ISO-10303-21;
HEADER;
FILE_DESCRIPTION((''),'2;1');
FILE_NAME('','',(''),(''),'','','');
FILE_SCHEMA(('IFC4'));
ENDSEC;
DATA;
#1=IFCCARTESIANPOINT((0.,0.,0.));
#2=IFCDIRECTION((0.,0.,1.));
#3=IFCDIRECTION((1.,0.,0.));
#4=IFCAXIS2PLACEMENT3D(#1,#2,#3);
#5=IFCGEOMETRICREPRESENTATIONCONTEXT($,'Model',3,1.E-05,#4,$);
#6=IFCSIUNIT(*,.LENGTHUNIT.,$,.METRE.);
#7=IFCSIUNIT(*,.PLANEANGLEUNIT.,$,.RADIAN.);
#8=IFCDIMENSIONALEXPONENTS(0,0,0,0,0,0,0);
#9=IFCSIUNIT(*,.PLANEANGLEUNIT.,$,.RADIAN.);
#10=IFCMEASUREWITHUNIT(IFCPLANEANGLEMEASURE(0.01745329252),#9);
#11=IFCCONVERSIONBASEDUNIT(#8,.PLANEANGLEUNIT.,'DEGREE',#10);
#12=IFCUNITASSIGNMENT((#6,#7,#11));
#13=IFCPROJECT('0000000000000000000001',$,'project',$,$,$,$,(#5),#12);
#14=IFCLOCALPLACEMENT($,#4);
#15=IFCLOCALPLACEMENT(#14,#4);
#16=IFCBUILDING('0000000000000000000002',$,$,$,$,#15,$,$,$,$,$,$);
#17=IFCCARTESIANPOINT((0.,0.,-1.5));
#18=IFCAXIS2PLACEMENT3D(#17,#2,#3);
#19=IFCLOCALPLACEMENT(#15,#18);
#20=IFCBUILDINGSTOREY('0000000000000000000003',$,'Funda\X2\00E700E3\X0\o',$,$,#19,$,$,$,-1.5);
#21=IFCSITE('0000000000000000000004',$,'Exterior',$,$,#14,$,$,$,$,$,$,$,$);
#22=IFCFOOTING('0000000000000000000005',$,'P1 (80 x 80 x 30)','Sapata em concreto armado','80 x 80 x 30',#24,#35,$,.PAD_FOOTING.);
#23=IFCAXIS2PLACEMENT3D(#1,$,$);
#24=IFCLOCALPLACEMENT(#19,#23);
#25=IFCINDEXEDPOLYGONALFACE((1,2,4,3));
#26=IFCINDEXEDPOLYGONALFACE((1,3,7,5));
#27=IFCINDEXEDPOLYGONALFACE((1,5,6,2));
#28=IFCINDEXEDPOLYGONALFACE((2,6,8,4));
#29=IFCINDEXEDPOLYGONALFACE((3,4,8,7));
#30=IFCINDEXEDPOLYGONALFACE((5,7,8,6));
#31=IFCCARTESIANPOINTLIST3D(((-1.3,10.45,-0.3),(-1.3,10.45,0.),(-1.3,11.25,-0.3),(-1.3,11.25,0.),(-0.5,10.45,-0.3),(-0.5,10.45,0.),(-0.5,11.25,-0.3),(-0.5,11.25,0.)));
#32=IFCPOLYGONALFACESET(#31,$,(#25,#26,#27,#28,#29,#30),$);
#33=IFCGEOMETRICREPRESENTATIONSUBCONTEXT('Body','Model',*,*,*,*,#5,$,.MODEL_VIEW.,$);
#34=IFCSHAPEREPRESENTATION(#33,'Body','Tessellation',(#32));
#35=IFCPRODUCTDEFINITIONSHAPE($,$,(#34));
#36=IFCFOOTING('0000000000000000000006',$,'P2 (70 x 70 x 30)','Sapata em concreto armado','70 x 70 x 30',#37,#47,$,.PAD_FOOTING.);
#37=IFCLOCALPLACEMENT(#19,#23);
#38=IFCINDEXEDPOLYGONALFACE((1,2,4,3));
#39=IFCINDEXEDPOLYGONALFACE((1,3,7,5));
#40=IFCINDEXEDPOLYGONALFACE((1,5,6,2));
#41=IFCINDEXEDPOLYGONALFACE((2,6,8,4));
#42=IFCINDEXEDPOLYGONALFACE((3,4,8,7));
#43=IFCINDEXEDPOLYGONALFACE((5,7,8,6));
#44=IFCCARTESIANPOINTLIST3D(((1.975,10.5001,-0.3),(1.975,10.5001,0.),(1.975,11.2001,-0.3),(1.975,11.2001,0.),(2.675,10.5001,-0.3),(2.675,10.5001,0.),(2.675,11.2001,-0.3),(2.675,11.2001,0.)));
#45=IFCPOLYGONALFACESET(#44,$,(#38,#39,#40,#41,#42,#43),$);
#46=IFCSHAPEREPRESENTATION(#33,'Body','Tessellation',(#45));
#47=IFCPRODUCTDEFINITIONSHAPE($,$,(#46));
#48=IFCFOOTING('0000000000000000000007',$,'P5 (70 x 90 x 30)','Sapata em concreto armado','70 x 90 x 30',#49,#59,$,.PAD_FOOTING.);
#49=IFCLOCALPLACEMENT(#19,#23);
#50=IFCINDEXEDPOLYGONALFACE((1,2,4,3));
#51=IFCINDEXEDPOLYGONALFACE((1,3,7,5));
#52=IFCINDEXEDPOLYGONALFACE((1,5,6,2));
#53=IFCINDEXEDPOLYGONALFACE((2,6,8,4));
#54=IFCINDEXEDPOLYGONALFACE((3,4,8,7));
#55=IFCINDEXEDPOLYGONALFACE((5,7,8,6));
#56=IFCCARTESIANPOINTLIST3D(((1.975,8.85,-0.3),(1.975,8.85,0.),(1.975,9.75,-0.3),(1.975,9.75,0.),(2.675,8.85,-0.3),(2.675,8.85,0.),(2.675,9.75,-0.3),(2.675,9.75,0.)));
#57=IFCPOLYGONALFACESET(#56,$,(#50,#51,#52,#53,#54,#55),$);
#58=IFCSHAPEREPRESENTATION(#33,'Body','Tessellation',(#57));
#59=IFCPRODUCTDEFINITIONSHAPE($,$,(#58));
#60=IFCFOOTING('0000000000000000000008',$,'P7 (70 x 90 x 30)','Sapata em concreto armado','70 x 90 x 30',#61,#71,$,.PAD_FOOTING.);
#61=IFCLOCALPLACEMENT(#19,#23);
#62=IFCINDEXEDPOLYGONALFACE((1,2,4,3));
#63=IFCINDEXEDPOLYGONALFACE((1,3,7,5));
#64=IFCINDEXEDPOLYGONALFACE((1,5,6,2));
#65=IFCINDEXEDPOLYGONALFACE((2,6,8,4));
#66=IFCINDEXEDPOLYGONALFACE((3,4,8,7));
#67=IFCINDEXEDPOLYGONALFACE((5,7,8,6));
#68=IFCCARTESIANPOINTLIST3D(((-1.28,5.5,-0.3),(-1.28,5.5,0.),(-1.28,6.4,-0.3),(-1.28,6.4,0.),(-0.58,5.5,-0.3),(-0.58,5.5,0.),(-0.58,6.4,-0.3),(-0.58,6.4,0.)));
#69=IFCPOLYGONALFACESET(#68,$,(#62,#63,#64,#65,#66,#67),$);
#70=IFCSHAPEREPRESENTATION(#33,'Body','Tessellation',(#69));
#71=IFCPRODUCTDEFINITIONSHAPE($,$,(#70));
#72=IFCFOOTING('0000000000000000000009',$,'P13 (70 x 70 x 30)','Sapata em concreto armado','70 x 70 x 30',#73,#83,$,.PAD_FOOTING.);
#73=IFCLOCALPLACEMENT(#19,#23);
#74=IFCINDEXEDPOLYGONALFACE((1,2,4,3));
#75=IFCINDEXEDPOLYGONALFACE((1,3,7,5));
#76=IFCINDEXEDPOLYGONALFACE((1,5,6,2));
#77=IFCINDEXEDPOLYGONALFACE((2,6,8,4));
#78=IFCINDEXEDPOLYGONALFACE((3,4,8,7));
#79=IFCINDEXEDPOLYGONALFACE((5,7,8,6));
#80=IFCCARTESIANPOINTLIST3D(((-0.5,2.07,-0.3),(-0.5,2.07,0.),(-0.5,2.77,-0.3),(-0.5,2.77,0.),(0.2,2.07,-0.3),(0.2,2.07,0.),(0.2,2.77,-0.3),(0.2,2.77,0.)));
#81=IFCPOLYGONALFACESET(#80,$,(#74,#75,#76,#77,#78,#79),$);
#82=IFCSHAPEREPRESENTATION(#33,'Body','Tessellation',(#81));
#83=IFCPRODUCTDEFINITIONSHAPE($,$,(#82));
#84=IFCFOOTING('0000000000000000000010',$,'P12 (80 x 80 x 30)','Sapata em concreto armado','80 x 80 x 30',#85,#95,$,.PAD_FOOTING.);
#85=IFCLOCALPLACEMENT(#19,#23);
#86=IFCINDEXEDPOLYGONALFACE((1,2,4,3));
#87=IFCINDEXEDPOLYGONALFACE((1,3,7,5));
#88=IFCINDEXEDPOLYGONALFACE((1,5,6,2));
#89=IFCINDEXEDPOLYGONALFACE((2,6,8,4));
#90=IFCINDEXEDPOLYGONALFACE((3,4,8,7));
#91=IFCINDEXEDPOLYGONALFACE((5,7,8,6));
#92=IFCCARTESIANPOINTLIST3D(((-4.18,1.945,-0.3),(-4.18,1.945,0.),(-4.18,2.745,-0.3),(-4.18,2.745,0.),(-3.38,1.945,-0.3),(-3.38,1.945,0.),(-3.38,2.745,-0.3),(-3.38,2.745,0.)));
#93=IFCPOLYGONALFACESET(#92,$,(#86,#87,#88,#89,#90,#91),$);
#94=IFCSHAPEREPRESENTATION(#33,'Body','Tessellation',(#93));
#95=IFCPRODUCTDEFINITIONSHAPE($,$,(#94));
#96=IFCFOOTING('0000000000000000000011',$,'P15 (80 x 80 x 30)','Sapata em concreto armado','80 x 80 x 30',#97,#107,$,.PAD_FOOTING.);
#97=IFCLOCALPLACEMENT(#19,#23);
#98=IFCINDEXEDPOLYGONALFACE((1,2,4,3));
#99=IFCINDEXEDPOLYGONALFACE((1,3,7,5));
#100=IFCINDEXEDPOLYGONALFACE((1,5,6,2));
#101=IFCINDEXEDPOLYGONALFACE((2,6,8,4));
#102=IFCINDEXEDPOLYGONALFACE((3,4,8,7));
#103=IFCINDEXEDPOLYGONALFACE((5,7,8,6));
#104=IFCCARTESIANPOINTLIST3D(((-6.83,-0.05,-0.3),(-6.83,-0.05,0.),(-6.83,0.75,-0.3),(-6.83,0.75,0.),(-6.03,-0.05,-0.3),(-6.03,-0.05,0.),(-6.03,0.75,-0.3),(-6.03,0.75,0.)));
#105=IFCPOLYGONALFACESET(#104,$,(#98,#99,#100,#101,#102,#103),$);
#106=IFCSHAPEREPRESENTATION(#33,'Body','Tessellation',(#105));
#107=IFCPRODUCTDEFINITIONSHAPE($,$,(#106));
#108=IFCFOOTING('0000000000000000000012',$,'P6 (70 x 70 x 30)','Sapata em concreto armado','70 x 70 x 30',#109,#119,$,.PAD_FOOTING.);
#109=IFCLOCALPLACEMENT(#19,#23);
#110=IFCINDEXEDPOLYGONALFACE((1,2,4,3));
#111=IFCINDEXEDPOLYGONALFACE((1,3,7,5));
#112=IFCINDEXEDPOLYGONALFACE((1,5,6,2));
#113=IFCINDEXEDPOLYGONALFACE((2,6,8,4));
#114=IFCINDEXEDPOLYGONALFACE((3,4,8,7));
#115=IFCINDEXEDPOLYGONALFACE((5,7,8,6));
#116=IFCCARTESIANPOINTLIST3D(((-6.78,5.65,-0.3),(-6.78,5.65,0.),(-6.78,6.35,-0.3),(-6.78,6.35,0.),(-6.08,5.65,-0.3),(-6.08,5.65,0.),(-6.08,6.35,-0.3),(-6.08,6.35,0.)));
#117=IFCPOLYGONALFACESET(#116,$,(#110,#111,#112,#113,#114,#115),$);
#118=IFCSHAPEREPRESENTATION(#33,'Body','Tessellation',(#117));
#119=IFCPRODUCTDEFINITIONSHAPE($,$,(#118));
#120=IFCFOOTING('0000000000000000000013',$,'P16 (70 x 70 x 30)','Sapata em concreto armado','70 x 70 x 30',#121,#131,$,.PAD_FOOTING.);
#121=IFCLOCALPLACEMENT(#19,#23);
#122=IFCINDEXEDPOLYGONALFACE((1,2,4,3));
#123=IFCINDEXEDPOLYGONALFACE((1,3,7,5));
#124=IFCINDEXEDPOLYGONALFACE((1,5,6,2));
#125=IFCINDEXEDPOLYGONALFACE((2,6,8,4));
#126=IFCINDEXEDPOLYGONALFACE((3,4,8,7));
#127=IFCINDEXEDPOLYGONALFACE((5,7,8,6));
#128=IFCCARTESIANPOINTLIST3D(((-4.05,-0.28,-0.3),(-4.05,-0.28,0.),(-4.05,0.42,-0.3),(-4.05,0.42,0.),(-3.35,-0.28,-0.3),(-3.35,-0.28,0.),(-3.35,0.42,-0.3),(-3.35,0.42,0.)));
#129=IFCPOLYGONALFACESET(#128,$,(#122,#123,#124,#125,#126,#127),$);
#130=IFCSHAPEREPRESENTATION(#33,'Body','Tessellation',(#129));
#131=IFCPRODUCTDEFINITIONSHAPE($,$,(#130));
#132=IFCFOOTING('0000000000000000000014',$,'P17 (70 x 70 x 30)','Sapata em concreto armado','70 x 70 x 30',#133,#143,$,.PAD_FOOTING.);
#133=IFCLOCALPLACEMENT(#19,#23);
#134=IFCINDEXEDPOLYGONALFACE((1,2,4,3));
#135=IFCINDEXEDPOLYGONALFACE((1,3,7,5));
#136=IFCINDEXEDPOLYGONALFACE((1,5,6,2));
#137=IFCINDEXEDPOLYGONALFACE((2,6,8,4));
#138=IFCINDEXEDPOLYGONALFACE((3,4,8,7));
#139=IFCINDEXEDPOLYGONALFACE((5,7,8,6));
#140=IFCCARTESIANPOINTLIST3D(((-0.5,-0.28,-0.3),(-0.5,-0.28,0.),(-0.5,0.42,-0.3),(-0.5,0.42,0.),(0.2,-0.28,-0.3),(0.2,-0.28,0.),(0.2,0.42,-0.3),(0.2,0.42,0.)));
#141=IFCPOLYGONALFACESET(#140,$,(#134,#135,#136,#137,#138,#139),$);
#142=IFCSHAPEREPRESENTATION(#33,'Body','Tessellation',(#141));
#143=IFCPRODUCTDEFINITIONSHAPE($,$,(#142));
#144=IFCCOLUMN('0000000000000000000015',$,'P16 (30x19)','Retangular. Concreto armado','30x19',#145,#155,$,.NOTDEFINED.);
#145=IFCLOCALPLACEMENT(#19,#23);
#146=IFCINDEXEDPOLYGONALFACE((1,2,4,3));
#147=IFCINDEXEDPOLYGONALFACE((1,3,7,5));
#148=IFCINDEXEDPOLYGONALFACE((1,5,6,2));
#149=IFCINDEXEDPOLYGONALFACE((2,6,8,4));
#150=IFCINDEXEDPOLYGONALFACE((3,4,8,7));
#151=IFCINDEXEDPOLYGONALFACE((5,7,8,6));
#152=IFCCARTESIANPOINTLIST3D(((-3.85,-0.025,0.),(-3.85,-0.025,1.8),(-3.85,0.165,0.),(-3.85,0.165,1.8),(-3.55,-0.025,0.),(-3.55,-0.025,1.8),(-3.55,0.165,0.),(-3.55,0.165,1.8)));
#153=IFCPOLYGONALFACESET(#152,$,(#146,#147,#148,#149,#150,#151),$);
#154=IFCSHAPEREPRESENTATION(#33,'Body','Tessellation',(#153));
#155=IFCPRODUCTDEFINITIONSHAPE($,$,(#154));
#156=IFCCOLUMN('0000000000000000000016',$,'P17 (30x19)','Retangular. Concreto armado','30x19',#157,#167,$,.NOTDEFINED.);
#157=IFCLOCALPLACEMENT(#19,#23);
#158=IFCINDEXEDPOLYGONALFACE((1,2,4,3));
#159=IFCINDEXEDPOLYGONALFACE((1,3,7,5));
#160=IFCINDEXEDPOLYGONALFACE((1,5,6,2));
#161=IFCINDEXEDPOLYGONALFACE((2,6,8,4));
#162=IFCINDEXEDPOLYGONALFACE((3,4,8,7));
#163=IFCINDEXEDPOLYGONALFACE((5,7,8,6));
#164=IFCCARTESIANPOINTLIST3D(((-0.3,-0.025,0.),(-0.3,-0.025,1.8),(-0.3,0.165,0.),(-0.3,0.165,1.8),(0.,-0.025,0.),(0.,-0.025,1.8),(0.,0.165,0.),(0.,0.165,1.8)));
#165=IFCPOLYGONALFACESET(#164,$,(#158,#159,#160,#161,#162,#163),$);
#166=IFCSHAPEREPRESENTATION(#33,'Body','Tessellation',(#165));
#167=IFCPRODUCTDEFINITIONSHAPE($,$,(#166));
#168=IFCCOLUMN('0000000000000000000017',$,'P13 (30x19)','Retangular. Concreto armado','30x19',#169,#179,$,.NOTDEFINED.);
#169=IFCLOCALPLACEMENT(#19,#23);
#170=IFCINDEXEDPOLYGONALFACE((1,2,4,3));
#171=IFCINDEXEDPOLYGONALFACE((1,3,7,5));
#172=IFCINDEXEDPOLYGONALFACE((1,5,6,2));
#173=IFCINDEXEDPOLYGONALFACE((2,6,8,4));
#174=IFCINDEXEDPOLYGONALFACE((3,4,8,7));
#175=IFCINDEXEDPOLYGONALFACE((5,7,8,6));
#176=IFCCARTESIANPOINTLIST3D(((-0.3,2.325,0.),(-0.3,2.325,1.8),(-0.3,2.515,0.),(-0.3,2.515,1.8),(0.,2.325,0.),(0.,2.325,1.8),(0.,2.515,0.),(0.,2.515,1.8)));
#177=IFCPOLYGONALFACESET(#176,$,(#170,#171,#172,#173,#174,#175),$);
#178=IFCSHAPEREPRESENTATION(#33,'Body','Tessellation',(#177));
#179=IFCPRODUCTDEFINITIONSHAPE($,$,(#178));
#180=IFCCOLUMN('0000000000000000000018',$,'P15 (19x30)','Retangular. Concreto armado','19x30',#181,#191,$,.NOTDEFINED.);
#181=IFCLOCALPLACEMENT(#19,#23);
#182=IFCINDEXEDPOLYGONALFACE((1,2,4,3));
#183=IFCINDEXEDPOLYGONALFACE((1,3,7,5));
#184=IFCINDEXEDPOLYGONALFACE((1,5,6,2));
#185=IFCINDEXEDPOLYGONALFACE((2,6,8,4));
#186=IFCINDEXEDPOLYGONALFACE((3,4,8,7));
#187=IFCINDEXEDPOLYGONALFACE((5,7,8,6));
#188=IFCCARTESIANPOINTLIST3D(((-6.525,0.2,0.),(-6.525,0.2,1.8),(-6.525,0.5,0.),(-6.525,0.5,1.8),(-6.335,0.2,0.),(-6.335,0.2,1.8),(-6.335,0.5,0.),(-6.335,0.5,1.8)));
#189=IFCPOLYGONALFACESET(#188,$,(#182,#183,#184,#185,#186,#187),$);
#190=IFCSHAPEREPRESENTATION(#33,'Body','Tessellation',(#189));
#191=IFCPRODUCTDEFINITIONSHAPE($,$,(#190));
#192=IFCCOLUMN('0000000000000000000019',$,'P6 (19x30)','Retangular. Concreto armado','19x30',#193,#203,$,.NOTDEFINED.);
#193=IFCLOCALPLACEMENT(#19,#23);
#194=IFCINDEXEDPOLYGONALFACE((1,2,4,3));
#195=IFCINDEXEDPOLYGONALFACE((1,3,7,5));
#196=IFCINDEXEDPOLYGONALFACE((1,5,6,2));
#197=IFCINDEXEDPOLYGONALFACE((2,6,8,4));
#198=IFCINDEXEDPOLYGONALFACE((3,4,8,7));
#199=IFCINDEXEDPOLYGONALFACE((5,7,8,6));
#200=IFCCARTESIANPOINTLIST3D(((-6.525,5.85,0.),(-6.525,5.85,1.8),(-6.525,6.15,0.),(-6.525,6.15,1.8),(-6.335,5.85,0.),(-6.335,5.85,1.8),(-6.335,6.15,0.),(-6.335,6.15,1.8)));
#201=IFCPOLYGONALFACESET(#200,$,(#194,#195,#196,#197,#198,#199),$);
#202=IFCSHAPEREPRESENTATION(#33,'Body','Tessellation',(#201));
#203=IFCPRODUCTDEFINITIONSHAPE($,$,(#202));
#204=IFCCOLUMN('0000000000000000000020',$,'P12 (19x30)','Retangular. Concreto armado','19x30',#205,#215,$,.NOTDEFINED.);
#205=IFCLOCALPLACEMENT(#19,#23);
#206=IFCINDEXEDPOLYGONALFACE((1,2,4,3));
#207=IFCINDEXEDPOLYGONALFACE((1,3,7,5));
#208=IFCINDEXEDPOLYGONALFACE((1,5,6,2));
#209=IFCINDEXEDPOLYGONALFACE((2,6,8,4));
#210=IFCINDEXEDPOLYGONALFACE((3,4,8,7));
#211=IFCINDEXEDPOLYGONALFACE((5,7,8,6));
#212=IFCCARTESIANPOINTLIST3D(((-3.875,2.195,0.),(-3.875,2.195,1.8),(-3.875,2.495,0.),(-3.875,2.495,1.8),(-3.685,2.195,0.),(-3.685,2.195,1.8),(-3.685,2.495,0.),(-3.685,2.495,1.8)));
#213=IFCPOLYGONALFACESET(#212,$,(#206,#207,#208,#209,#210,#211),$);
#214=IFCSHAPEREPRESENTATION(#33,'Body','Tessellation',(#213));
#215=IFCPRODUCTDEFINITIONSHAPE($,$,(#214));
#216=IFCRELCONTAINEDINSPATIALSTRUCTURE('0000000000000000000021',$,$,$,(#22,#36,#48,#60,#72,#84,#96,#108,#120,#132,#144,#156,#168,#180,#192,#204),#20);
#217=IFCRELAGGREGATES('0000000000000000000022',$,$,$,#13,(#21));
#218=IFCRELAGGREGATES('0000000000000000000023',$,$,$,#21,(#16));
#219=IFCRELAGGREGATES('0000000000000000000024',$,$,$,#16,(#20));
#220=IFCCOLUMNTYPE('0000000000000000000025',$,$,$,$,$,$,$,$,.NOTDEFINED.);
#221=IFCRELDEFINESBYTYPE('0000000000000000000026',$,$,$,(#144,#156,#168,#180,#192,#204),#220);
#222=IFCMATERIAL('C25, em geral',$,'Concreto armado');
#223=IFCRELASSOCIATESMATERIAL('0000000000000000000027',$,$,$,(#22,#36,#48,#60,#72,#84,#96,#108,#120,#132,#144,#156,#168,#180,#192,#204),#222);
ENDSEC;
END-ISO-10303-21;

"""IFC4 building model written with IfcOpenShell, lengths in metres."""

from ifc_helpers import new_model, entity, si_unit, converted_unit, frame, frame_2d, origin_with_axes, origin_2d_with_axis, place, context, subcontext, project, spatial, rectangle, extrude, material, type_object, element, save


model = new_model("IFC4")

# Units and contexts
model_context = context("Model", 3, precision=1e-05, world=origin_with_axes())
body_context = subcontext(model_context, "Body", "Model", "MODEL_VIEW")
ifc_project = project(units=[si_unit("LENGTHUNIT", "METRE"), si_unit("PLANEANGLEUNIT", "RADIAN"), converted_unit("PLANEANGLEUNIT", "DEGREE", entity("IfcPlaneAngleMeasure", 0.01745329252), si_unit("PLANEANGLEUNIT", "RADIAN"), dimensions=[0, 0, 0, 0, 0, 0, 0])], contexts=[model_context])

# Site, building, storey
site_placement = place(None, origin_with_axes())
site = spatial("IfcSite", under=ifc_project, at=site_placement, Name="Exterior")
building_placement = place(site_placement, origin_with_axes())
building = spatial("IfcBuilding", under=site, at=building_placement)
storey_placement = place(building_placement, frame((0.0, 0.0, -1.5), z_axis=(0.0, 0.0, 1.0), x_axis=(1.0, 0.0, 0.0)))
storey = spatial("IfcBuildingStorey", under=building, at=storey_placement, Name="Fundação", Elevation=-1.5)

# Footings
ifc_material = material(Name="C25, em geral", Category="Concreto armado")
footing_1_placement = place(storey_placement, frame((-0.9, 10.85, -0.3), z_axis=(0.0, 0.0, 1.0), x_axis=(1.0, 0.0, 0.0)))
element("IfcFooting", 1, at=footing_1_placement, inside=storey, material=ifc_material, Name="P1 (80 x 80 x 30)", Description="Sapata em concreto armado", ObjectType="80 x 80 x 30", PredefinedType="PAD_FOOTING", context=body_context, shape_type="SweptSolid", body=[
    extrude(rectangle(XDim=0.8, YDim=0.8, at=origin_2d_with_axis()), origin_with_axes(), (0.0, 0.0, 1.0), 0.3),
])
footing_2_placement = place(storey_placement, frame((2.325, 10.8501, -0.3), z_axis=(0.0, 0.0, 1.0), x_axis=(1.0, 0.0, 0.0)))
element("IfcFooting", 2, at=footing_2_placement, inside=storey, material=ifc_material, Name="P2 (70 x 70 x 30)", Description="Sapata em concreto armado", ObjectType="70 x 70 x 30", PredefinedType="PAD_FOOTING", context=body_context, shape_type="SweptSolid", body=[
    extrude(rectangle(XDim=0.7, YDim=0.7, at=origin_2d_with_axis()), origin_with_axes(), (0.0, 0.0, 1.0), 0.3),
])
for number, where, z_axis, x_axis, name in (
    (3, (2.325, 9.3, -0.3), (0.0, 0.0, 1.0), (1.0, 0.0, 0.0), "P5 (70 x 90 x 30)"),
    (4, (-0.93, 5.95, -0.3), (0.0, 0.0, 1.0), (1.0, 0.0, 0.0), "P7 (70 x 90 x 30)"),
):
    element("IfcFooting", number, at=place(storey_placement, frame(where, z_axis=z_axis, x_axis=x_axis)), inside=storey, material=ifc_material, Name=name, Description="Sapata em concreto armado", ObjectType="70 x 90 x 30", PredefinedType="PAD_FOOTING", context=body_context, shape_type="SweptSolid", body=[
        extrude(rectangle(XDim=0.7, YDim=0.9, at=origin_2d_with_axis()), origin_with_axes(), (0.0, 0.0, 1.0), 0.3),
    ])
footing_3_placement = place(storey_placement, frame((-0.15, 2.42, -0.3), z_axis=(0.0, 0.0, 1.0), x_axis=(1.0, 0.0, 0.0)))
element("IfcFooting", 5, at=footing_3_placement, inside=storey, material=ifc_material, Name="P13 (70 x 70 x 30)", Description="Sapata em concreto armado", ObjectType="70 x 70 x 30", PredefinedType="PAD_FOOTING", context=body_context, shape_type="SweptSolid", body=[
    extrude(rectangle(XDim=0.7, YDim=0.7, at=origin_2d_with_axis()), origin_with_axes(), (0.0, 0.0, 1.0), 0.3),
])
for number, where, z_axis, x_axis, name in (
    (6, (-3.78, 2.345, -0.3), (0.0, 0.0, 1.0), (1.0, 0.0, 0.0), "P12 (80 x 80 x 30)"),
    (7, (-6.43, 0.35, -0.3), (0.0, 0.0, 1.0), (1.0, 0.0, 0.0), "P15 (80 x 80 x 30)"),
):
    element("IfcFooting", number, at=place(storey_placement, frame(where, z_axis=z_axis, x_axis=x_axis)), inside=storey, material=ifc_material, Name=name, Description="Sapata em concreto armado", ObjectType="80 x 80 x 30", PredefinedType="PAD_FOOTING", context=body_context, shape_type="SweptSolid", body=[
        extrude(rectangle(XDim=0.8, YDim=0.8, at=origin_2d_with_axis()), origin_with_axes(), (0.0, 0.0, 1.0), 0.3),
    ])
for number, where, z_axis, x_axis, name in (
    (8, (-6.43, 6.0, -0.3), (0.0, 0.0, 1.0), (1.0, 0.0, 0.0), "P6 (70 x 70 x 30)"),
    (9, (-3.7, 0.07, -0.3), (0.0, 0.0, 1.0), (1.0, 0.0, 0.0), "P16 (70 x 70 x 30)"),
    (10, (-0.15, 0.07, -0.3), (0.0, 0.0, 1.0), (1.0, 0.0, 0.0), "P17 (70 x 70 x 30)"),
):
    element("IfcFooting", number, at=place(storey_placement, frame(where, z_axis=z_axis, x_axis=x_axis)), inside=storey, material=ifc_material, Name=name, Description="Sapata em concreto armado", ObjectType="70 x 70 x 30", PredefinedType="PAD_FOOTING", context=body_context, shape_type="SweptSolid", body=[
        extrude(rectangle(XDim=0.7, YDim=0.7, at=origin_2d_with_axis()), origin_with_axes(), (0.0, 0.0, 1.0), 0.3),
    ])

# Columns
column_type = type_object("IfcColumnType", PredefinedType="NOTDEFINED")
for number, where, z_axis, x_axis, name in (
    (11, (-3.7, 0.07, 0.0), (0.0, 0.0, 1.0), (1.0, 0.0, 0.0), "P16 (30x19)"),
    (12, (-0.15, 0.07, 0.0), (0.0, 0.0, 1.0), (1.0, 0.0, 0.0), "P17 (30x19)"),
    (13, (-0.15, 2.42, 0.0), (0.0, 0.0, 1.0), (1.0, 0.0, 0.0), "P13 (30x19)"),
):
    element("IfcColumn", number, at=place(storey_placement, frame(where, z_axis=z_axis, x_axis=x_axis)), inside=storey, type_object=column_type, material=ifc_material, Name=name, Description="Retangular. Concreto armado", ObjectType="30x19", PredefinedType="NOTDEFINED", context=body_context, shape_type="SweptSolid", body=[
        extrude(rectangle(XDim=0.3, YDim=0.19, at=origin_2d_with_axis()), origin_with_axes(), (0.0, 0.0, 1.0), 1.8),
    ])
column_1_placement = place(storey_placement, frame((-6.43, 0.35, 0.0), z_axis=(0.0, 0.0, 1.0), x_axis=(1.0, 0.0, 0.0)))
element("IfcColumn", 14, at=column_1_placement, inside=storey, type_object=column_type, material=ifc_material, Name="P15 (19x30)", Description="Retangular. Concreto armado", ObjectType="19x30", PredefinedType="NOTDEFINED", context=body_context, shape_type="SweptSolid", body=[
    extrude(rectangle(XDim=0.19, YDim=0.3, at=origin_2d_with_axis()), origin_with_axes(), (0.0, 0.0, 1.0), 1.8),
])
column_2_placement = place(storey_placement, frame((-6.43, 6.15, 0.0), z_axis=(0.0, 0.0, 1.0), x_axis=(1.0, 0.0, 0.0)))
element("IfcColumn", 15, at=column_2_placement, inside=storey, type_object=column_type, material=ifc_material, Name="P6 (19x30)", Description="Retangular. Concreto armado", ObjectType="19x30", PredefinedType="NOTDEFINED", context=body_context, shape_type="SweptSolid", body=[
    extrude(rectangle(XDim=0.19, YDim=0.3, at=frame_2d((0.0, -0.15), x_axis=(1.0, 0.0))), origin_with_axes(), (0.0, 0.0, 1.0), 1.8),
])
column_3_placement = place(storey_placement, frame((-3.78, 2.345, 0.0), z_axis=(0.0, 0.0, 1.0), x_axis=(1.0, 0.0, 0.0)))
element("IfcColumn", 16, at=column_3_placement, inside=storey, type_object=column_type, material=ifc_material, Name="P12 (19x30)", Description="Retangular. Concreto armado", ObjectType="19x30", PredefinedType="NOTDEFINED", context=body_context, shape_type="SweptSolid", body=[
    extrude(rectangle(XDim=0.19, YDim=0.3, at=origin_2d_with_axis()), origin_with_axes(), (0.0, 0.0, 1.0), 1.8),
])

save(model, "model.ifc")
